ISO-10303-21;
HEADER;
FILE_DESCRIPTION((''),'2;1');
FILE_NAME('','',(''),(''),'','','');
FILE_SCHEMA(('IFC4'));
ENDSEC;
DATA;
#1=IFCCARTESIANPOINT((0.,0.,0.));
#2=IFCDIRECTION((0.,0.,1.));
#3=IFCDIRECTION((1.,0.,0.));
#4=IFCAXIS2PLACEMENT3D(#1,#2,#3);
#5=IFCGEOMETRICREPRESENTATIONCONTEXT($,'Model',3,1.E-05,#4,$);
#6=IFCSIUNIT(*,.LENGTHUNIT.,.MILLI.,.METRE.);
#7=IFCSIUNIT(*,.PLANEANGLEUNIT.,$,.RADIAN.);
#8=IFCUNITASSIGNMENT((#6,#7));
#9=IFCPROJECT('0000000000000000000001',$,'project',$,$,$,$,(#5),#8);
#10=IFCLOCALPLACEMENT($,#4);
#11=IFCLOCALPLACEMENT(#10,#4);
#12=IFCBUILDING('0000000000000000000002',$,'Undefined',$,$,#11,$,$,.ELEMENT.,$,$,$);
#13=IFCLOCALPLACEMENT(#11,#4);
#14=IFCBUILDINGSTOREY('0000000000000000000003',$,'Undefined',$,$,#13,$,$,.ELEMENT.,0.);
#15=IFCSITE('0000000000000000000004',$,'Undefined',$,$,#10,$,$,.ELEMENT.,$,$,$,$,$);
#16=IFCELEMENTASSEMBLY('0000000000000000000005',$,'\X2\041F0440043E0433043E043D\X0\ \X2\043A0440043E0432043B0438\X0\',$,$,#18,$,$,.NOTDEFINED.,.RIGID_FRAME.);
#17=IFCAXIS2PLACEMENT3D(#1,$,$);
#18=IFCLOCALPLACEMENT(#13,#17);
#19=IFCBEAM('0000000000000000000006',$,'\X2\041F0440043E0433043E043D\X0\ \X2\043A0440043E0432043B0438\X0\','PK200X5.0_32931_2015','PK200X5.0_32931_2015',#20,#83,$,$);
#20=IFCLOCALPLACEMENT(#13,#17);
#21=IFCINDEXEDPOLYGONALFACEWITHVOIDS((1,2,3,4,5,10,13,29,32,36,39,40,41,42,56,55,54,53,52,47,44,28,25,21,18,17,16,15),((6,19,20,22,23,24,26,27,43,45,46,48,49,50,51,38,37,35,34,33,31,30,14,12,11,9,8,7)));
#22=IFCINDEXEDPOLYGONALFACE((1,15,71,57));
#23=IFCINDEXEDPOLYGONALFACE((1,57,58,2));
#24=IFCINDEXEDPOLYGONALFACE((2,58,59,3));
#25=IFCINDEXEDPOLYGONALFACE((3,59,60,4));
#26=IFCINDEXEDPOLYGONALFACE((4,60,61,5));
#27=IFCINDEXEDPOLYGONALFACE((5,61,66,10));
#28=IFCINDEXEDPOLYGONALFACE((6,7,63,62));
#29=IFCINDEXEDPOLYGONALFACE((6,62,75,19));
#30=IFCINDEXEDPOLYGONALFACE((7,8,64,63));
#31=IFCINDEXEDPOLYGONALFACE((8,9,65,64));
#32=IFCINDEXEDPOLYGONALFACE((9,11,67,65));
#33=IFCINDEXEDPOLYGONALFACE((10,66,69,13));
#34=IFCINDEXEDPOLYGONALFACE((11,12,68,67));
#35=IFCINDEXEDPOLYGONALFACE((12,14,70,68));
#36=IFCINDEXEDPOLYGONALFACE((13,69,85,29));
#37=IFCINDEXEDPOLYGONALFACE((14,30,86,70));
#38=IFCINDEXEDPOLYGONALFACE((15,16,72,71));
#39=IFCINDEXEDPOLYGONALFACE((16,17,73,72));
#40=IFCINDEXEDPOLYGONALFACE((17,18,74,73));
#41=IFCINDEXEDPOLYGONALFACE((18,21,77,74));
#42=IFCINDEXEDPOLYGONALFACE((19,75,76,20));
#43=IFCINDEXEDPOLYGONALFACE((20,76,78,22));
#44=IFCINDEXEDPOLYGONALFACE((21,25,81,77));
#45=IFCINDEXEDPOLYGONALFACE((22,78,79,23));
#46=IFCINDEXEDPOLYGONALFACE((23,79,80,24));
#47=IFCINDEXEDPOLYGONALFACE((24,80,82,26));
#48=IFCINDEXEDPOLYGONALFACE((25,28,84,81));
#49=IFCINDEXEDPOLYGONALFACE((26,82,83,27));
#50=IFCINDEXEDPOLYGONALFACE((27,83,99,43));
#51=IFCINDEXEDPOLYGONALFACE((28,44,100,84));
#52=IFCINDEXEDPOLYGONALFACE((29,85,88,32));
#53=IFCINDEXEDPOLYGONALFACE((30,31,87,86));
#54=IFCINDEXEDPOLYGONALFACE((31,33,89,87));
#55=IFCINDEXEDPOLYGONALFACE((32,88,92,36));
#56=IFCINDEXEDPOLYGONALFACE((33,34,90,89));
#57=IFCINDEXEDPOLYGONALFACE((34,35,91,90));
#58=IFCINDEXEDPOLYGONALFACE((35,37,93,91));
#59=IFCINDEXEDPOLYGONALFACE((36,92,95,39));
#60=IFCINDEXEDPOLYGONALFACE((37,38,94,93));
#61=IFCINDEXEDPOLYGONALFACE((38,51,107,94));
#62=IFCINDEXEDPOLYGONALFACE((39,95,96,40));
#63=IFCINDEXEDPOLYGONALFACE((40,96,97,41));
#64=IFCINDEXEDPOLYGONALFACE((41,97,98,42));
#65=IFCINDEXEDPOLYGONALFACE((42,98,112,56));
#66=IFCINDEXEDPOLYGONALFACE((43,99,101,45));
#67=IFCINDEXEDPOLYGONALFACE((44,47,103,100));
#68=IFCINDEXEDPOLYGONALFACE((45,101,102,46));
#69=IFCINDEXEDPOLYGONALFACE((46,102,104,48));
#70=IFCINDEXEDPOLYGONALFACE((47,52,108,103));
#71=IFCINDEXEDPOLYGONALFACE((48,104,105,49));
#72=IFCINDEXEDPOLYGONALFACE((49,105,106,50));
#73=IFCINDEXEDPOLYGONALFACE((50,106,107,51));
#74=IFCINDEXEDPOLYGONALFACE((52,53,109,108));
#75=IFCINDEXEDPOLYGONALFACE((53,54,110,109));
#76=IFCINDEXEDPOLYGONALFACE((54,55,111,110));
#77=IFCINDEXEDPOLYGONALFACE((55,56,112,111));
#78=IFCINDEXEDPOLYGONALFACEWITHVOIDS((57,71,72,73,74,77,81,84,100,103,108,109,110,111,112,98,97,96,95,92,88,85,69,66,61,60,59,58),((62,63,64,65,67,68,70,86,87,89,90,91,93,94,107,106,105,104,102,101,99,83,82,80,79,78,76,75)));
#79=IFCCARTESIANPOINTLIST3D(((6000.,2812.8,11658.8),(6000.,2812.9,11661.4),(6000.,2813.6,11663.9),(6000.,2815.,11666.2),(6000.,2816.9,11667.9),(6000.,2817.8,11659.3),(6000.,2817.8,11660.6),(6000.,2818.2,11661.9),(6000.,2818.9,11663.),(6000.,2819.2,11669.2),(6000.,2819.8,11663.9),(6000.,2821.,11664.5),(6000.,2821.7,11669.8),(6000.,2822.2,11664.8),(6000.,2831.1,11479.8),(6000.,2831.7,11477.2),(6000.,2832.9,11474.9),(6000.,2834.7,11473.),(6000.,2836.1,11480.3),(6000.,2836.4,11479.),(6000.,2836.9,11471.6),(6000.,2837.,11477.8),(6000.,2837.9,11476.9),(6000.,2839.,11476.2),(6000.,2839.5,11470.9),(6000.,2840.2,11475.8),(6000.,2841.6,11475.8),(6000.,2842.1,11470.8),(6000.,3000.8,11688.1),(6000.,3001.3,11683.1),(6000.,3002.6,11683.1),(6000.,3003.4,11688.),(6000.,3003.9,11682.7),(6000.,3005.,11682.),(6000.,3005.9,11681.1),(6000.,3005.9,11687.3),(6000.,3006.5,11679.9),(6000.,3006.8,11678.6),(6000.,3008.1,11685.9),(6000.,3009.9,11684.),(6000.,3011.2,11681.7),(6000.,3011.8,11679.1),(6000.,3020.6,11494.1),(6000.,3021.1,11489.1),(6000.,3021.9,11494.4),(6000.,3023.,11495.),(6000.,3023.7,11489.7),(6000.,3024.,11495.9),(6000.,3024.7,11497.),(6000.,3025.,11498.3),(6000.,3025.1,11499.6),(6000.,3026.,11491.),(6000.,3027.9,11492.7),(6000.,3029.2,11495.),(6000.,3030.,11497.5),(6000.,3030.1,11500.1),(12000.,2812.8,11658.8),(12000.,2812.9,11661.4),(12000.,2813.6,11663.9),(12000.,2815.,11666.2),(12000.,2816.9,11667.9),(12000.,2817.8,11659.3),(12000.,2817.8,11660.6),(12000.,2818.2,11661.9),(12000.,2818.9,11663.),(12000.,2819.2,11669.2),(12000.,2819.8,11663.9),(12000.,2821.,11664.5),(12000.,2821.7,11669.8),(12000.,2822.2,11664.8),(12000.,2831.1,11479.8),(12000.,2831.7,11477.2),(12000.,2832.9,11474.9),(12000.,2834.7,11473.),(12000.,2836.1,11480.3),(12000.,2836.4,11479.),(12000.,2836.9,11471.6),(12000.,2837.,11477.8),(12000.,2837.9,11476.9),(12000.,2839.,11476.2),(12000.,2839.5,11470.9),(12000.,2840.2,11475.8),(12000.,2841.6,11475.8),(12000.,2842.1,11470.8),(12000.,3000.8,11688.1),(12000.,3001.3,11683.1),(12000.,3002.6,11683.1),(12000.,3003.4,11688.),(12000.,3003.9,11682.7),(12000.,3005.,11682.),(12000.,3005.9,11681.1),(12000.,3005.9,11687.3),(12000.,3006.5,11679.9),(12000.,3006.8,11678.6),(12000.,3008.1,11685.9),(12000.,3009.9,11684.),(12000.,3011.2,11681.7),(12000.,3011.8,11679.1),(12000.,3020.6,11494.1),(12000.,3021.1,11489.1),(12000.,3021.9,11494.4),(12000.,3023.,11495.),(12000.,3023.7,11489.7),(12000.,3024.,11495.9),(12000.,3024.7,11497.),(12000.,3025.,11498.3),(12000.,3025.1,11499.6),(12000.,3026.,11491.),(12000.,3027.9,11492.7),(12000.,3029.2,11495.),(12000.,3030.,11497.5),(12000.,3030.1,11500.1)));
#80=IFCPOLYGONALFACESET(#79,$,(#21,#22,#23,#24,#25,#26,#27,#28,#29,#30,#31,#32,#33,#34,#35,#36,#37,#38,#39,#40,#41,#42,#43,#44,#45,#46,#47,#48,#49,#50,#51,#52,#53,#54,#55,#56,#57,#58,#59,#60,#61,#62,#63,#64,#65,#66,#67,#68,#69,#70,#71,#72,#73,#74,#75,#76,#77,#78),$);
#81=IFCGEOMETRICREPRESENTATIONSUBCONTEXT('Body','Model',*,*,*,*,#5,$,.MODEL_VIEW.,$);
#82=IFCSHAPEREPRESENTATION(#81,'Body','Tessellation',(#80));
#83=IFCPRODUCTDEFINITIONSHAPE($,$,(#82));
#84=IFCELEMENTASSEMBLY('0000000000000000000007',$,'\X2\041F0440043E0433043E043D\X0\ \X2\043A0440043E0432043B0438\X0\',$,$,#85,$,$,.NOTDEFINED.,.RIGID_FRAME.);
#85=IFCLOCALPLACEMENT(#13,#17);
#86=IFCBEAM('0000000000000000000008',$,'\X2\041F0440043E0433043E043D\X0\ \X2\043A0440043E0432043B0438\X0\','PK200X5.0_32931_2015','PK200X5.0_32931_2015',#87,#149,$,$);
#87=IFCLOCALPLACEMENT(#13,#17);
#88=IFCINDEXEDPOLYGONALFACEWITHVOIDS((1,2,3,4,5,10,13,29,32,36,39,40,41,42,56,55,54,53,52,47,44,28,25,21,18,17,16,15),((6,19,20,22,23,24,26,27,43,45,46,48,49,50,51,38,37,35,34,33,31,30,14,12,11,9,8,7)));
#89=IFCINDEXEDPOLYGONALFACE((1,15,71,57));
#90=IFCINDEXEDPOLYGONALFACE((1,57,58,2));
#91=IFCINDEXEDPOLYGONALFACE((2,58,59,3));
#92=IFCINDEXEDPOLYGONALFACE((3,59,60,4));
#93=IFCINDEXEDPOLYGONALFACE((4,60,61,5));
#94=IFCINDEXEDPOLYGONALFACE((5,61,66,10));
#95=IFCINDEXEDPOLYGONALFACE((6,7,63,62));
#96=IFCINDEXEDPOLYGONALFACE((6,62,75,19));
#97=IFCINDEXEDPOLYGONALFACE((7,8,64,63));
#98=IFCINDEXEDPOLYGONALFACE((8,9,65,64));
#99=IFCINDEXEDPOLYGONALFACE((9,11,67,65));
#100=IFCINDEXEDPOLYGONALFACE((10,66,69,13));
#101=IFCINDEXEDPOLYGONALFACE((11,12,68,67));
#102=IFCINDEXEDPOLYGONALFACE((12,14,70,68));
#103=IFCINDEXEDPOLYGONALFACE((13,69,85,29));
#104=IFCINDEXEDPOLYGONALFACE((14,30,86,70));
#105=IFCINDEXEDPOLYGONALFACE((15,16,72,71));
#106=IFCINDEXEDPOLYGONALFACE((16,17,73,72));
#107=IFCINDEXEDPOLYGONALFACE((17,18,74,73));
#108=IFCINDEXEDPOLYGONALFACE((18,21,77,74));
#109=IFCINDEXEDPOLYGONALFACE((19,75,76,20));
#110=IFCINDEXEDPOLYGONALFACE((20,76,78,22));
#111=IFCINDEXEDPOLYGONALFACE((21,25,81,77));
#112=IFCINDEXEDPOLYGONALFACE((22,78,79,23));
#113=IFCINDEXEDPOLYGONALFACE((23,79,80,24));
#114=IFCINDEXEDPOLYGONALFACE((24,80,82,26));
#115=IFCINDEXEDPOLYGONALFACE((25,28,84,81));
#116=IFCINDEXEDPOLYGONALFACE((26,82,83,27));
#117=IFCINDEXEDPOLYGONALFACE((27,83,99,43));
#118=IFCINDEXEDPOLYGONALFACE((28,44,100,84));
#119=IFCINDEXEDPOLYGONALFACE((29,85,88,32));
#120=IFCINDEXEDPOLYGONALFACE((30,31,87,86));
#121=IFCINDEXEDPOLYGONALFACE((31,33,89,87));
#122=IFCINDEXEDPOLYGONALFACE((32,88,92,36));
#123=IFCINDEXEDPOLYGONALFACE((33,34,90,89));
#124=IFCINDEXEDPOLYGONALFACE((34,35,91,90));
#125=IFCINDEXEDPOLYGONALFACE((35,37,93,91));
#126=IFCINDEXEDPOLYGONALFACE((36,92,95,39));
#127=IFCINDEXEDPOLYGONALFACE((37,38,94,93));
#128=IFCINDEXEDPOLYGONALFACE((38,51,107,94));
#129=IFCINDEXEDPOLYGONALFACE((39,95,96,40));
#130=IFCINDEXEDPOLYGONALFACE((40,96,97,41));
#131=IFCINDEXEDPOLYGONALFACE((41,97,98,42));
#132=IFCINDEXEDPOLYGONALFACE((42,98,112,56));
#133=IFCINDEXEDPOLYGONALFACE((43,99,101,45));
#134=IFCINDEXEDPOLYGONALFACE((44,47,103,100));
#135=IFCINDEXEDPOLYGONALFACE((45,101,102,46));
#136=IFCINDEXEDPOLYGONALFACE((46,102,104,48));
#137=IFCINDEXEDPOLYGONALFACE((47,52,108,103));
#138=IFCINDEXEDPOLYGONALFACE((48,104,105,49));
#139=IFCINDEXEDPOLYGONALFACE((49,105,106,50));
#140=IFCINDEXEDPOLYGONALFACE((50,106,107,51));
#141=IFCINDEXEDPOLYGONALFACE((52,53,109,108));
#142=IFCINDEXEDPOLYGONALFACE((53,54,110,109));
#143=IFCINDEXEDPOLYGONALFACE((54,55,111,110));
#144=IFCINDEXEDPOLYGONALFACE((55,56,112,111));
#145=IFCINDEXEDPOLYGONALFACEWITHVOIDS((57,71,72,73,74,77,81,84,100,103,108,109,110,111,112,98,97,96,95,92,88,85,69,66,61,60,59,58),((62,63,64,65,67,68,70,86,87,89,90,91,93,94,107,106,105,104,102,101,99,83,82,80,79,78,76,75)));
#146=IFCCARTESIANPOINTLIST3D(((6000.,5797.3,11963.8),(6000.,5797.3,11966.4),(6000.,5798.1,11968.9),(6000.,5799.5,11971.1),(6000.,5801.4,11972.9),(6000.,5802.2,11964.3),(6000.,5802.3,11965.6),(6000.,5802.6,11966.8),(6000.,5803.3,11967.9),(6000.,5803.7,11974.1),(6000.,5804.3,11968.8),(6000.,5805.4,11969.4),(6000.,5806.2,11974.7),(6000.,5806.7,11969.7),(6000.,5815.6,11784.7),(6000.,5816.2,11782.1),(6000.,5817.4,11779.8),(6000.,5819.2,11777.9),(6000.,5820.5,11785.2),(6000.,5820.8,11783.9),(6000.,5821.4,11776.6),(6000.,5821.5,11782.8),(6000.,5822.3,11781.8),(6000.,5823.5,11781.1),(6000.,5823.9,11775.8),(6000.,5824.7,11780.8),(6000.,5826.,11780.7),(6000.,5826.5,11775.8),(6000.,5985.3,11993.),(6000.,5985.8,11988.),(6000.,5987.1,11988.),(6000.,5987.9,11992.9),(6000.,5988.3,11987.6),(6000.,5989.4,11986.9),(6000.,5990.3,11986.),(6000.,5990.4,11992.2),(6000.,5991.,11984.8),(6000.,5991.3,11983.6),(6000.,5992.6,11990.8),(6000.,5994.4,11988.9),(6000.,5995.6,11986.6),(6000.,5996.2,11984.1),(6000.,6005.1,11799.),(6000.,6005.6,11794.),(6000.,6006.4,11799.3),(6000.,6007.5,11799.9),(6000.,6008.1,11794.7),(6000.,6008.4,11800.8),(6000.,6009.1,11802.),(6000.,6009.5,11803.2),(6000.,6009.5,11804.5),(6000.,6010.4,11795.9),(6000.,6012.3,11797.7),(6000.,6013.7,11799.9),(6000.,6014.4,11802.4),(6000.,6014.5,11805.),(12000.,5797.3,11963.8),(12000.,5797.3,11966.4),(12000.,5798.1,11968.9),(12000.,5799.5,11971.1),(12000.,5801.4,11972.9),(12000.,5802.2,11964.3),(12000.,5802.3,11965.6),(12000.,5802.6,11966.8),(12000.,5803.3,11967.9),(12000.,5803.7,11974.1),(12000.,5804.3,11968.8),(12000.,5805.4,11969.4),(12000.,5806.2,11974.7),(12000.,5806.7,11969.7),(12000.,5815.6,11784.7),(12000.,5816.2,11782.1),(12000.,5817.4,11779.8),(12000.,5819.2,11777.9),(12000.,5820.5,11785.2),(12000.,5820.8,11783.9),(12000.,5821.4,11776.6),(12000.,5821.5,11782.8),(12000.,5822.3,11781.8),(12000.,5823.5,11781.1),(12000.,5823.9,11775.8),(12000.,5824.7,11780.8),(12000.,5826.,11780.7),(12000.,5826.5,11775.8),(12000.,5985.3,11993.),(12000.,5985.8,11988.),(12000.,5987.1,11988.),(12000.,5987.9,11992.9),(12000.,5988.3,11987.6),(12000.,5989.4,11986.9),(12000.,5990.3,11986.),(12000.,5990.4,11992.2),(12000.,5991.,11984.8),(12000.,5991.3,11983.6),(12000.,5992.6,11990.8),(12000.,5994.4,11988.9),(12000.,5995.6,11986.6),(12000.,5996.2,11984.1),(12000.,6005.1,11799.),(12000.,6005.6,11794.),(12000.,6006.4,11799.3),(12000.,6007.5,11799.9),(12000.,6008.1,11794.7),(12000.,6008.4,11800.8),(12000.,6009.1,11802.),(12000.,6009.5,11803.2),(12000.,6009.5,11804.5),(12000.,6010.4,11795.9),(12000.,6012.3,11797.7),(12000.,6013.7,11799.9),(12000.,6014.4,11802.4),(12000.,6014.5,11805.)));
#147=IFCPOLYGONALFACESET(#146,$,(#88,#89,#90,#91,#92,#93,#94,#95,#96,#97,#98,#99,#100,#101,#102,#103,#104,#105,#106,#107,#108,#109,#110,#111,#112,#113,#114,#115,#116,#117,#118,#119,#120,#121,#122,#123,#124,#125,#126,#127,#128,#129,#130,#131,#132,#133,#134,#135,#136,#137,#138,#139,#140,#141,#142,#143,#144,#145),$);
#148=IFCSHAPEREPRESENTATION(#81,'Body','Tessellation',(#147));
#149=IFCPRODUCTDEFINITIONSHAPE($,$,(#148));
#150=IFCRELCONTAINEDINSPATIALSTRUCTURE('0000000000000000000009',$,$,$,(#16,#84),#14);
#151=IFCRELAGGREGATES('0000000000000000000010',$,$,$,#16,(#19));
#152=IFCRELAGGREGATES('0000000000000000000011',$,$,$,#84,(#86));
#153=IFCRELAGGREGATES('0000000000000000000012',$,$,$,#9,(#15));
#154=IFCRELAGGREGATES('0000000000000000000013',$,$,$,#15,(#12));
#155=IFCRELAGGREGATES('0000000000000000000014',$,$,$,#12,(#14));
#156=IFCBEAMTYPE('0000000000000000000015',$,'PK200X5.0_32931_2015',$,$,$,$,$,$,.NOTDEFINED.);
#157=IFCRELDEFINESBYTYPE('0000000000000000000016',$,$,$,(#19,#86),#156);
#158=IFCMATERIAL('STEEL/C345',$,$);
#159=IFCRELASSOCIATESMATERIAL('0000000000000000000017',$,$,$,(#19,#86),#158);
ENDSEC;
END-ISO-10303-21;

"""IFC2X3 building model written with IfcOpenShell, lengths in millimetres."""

from ifc_helpers import new_model, si_unit, frame, origin_with_axes, origin_2d_with_axis, place, context, subcontext, project, spatial, hollow_rectangle, extrude, material, type_object, element, aggregate, save


model = new_model("IFC2X3")

# Units and contexts
model_context = context("Model", 3, precision=1e-05, world=origin_with_axes())
body_context = subcontext(model_context, "Body", "Model", "MODEL_VIEW")
ifc_project = project(units=[si_unit("LENGTHUNIT", "METRE", prefix="MILLI"), si_unit("PLANEANGLEUNIT", "RADIAN")], contexts=[model_context])

# Site, building, storey
site_placement = place(None, origin_with_axes())
site = spatial("IfcSite", under=ifc_project, at=site_placement, Name="Undefined", CompositionType="ELEMENT")
building_placement = place(site_placement, origin_with_axes())
building = spatial("IfcBuilding", under=site, at=building_placement, Name="Undefined", CompositionType="ELEMENT")
storey_placement = place(building_placement, origin_with_axes())
storey = spatial("IfcBuildingStorey", under=building, at=storey_placement, Name="Undefined", CompositionType="ELEMENT", Elevation=0.0)

# Element assemblies, beams
assembly_1_placement = place(storey_placement, origin_with_axes())
assembly_1 = element("IfcElementAssembly", 1, at=assembly_1_placement, inside=storey, Name="Прогон кровли", AssemblyPlace="NOTDEFINED", PredefinedType="RIGID_FRAME")
ifc_material_1 = material(Name="STEEL/C345")
beam_type_1 = type_object("IfcBeamType", Name="PK200X5.0_32931_2015", PredefinedType="NOTDEFINED")
beam_1_placement = place(assembly_1_placement, frame((12000.0, 2921.4, 11579.4), z_axis=(0.0, -0.101645, 0.994821), x_axis=(-1.0, 0.0, 0.0)))
beam_1 = element("IfcBeam", 2, at=beam_1_placement, type_object=beam_type_1, material=ifc_material_1, Name="Прогон кровли", Description="PK200X5.0_32931_2015", ObjectType="PK200X5.0_32931_2015", context=body_context, shape_type="SweptSolid", body=[
    extrude(hollow_rectangle(XDim=200.0, YDim=200.0, WallThickness=5.0, InnerFilletRadius=5.0, OuterFilletRadius=10.0, at=origin_2d_with_axis()), frame((6000.0, 0.0, 0.0), z_axis=(-1.0, 0.0, 0.0), x_axis=(0.0, -1.0, 0.0)), (0.0, 0.0, 1.0), 6000.0),
])
aggregate(assembly_1, [beam_1])
assembly_2_placement = place(storey_placement, origin_with_axes())
assembly_2 = element("IfcElementAssembly", 3, at=assembly_2_placement, inside=storey, Name="Прогон кровли", AssemblyPlace="NOTDEFINED", PredefinedType="RIGID_FRAME")
beam_2_placement = place(assembly_2_placement, frame((12000.0, 5905.9, 11884.4), z_axis=(0.0, -0.101645, 0.994821), x_axis=(-1.0, 0.0, 0.0)))
beam_2 = element("IfcBeam", 4, at=beam_2_placement, type_object=beam_type_1, material=ifc_material_1, Name="Прогон кровли", Description="PK200X5.0_32931_2015", ObjectType="PK200X5.0_32931_2015", context=body_context, shape_type="SweptSolid", body=[
    extrude(hollow_rectangle(XDim=200.0, YDim=200.0, WallThickness=5.0, InnerFilletRadius=5.0, OuterFilletRadius=10.0, at=origin_2d_with_axis()), frame((6000.0, 0.0, 0.0), z_axis=(-1.0, 0.0, 0.0), x_axis=(0.0, -1.0, 0.0)), (0.0, 0.0, 1.0), 6000.0),
])
aggregate(assembly_2, [beam_2])

save(model, "model.ifc")
